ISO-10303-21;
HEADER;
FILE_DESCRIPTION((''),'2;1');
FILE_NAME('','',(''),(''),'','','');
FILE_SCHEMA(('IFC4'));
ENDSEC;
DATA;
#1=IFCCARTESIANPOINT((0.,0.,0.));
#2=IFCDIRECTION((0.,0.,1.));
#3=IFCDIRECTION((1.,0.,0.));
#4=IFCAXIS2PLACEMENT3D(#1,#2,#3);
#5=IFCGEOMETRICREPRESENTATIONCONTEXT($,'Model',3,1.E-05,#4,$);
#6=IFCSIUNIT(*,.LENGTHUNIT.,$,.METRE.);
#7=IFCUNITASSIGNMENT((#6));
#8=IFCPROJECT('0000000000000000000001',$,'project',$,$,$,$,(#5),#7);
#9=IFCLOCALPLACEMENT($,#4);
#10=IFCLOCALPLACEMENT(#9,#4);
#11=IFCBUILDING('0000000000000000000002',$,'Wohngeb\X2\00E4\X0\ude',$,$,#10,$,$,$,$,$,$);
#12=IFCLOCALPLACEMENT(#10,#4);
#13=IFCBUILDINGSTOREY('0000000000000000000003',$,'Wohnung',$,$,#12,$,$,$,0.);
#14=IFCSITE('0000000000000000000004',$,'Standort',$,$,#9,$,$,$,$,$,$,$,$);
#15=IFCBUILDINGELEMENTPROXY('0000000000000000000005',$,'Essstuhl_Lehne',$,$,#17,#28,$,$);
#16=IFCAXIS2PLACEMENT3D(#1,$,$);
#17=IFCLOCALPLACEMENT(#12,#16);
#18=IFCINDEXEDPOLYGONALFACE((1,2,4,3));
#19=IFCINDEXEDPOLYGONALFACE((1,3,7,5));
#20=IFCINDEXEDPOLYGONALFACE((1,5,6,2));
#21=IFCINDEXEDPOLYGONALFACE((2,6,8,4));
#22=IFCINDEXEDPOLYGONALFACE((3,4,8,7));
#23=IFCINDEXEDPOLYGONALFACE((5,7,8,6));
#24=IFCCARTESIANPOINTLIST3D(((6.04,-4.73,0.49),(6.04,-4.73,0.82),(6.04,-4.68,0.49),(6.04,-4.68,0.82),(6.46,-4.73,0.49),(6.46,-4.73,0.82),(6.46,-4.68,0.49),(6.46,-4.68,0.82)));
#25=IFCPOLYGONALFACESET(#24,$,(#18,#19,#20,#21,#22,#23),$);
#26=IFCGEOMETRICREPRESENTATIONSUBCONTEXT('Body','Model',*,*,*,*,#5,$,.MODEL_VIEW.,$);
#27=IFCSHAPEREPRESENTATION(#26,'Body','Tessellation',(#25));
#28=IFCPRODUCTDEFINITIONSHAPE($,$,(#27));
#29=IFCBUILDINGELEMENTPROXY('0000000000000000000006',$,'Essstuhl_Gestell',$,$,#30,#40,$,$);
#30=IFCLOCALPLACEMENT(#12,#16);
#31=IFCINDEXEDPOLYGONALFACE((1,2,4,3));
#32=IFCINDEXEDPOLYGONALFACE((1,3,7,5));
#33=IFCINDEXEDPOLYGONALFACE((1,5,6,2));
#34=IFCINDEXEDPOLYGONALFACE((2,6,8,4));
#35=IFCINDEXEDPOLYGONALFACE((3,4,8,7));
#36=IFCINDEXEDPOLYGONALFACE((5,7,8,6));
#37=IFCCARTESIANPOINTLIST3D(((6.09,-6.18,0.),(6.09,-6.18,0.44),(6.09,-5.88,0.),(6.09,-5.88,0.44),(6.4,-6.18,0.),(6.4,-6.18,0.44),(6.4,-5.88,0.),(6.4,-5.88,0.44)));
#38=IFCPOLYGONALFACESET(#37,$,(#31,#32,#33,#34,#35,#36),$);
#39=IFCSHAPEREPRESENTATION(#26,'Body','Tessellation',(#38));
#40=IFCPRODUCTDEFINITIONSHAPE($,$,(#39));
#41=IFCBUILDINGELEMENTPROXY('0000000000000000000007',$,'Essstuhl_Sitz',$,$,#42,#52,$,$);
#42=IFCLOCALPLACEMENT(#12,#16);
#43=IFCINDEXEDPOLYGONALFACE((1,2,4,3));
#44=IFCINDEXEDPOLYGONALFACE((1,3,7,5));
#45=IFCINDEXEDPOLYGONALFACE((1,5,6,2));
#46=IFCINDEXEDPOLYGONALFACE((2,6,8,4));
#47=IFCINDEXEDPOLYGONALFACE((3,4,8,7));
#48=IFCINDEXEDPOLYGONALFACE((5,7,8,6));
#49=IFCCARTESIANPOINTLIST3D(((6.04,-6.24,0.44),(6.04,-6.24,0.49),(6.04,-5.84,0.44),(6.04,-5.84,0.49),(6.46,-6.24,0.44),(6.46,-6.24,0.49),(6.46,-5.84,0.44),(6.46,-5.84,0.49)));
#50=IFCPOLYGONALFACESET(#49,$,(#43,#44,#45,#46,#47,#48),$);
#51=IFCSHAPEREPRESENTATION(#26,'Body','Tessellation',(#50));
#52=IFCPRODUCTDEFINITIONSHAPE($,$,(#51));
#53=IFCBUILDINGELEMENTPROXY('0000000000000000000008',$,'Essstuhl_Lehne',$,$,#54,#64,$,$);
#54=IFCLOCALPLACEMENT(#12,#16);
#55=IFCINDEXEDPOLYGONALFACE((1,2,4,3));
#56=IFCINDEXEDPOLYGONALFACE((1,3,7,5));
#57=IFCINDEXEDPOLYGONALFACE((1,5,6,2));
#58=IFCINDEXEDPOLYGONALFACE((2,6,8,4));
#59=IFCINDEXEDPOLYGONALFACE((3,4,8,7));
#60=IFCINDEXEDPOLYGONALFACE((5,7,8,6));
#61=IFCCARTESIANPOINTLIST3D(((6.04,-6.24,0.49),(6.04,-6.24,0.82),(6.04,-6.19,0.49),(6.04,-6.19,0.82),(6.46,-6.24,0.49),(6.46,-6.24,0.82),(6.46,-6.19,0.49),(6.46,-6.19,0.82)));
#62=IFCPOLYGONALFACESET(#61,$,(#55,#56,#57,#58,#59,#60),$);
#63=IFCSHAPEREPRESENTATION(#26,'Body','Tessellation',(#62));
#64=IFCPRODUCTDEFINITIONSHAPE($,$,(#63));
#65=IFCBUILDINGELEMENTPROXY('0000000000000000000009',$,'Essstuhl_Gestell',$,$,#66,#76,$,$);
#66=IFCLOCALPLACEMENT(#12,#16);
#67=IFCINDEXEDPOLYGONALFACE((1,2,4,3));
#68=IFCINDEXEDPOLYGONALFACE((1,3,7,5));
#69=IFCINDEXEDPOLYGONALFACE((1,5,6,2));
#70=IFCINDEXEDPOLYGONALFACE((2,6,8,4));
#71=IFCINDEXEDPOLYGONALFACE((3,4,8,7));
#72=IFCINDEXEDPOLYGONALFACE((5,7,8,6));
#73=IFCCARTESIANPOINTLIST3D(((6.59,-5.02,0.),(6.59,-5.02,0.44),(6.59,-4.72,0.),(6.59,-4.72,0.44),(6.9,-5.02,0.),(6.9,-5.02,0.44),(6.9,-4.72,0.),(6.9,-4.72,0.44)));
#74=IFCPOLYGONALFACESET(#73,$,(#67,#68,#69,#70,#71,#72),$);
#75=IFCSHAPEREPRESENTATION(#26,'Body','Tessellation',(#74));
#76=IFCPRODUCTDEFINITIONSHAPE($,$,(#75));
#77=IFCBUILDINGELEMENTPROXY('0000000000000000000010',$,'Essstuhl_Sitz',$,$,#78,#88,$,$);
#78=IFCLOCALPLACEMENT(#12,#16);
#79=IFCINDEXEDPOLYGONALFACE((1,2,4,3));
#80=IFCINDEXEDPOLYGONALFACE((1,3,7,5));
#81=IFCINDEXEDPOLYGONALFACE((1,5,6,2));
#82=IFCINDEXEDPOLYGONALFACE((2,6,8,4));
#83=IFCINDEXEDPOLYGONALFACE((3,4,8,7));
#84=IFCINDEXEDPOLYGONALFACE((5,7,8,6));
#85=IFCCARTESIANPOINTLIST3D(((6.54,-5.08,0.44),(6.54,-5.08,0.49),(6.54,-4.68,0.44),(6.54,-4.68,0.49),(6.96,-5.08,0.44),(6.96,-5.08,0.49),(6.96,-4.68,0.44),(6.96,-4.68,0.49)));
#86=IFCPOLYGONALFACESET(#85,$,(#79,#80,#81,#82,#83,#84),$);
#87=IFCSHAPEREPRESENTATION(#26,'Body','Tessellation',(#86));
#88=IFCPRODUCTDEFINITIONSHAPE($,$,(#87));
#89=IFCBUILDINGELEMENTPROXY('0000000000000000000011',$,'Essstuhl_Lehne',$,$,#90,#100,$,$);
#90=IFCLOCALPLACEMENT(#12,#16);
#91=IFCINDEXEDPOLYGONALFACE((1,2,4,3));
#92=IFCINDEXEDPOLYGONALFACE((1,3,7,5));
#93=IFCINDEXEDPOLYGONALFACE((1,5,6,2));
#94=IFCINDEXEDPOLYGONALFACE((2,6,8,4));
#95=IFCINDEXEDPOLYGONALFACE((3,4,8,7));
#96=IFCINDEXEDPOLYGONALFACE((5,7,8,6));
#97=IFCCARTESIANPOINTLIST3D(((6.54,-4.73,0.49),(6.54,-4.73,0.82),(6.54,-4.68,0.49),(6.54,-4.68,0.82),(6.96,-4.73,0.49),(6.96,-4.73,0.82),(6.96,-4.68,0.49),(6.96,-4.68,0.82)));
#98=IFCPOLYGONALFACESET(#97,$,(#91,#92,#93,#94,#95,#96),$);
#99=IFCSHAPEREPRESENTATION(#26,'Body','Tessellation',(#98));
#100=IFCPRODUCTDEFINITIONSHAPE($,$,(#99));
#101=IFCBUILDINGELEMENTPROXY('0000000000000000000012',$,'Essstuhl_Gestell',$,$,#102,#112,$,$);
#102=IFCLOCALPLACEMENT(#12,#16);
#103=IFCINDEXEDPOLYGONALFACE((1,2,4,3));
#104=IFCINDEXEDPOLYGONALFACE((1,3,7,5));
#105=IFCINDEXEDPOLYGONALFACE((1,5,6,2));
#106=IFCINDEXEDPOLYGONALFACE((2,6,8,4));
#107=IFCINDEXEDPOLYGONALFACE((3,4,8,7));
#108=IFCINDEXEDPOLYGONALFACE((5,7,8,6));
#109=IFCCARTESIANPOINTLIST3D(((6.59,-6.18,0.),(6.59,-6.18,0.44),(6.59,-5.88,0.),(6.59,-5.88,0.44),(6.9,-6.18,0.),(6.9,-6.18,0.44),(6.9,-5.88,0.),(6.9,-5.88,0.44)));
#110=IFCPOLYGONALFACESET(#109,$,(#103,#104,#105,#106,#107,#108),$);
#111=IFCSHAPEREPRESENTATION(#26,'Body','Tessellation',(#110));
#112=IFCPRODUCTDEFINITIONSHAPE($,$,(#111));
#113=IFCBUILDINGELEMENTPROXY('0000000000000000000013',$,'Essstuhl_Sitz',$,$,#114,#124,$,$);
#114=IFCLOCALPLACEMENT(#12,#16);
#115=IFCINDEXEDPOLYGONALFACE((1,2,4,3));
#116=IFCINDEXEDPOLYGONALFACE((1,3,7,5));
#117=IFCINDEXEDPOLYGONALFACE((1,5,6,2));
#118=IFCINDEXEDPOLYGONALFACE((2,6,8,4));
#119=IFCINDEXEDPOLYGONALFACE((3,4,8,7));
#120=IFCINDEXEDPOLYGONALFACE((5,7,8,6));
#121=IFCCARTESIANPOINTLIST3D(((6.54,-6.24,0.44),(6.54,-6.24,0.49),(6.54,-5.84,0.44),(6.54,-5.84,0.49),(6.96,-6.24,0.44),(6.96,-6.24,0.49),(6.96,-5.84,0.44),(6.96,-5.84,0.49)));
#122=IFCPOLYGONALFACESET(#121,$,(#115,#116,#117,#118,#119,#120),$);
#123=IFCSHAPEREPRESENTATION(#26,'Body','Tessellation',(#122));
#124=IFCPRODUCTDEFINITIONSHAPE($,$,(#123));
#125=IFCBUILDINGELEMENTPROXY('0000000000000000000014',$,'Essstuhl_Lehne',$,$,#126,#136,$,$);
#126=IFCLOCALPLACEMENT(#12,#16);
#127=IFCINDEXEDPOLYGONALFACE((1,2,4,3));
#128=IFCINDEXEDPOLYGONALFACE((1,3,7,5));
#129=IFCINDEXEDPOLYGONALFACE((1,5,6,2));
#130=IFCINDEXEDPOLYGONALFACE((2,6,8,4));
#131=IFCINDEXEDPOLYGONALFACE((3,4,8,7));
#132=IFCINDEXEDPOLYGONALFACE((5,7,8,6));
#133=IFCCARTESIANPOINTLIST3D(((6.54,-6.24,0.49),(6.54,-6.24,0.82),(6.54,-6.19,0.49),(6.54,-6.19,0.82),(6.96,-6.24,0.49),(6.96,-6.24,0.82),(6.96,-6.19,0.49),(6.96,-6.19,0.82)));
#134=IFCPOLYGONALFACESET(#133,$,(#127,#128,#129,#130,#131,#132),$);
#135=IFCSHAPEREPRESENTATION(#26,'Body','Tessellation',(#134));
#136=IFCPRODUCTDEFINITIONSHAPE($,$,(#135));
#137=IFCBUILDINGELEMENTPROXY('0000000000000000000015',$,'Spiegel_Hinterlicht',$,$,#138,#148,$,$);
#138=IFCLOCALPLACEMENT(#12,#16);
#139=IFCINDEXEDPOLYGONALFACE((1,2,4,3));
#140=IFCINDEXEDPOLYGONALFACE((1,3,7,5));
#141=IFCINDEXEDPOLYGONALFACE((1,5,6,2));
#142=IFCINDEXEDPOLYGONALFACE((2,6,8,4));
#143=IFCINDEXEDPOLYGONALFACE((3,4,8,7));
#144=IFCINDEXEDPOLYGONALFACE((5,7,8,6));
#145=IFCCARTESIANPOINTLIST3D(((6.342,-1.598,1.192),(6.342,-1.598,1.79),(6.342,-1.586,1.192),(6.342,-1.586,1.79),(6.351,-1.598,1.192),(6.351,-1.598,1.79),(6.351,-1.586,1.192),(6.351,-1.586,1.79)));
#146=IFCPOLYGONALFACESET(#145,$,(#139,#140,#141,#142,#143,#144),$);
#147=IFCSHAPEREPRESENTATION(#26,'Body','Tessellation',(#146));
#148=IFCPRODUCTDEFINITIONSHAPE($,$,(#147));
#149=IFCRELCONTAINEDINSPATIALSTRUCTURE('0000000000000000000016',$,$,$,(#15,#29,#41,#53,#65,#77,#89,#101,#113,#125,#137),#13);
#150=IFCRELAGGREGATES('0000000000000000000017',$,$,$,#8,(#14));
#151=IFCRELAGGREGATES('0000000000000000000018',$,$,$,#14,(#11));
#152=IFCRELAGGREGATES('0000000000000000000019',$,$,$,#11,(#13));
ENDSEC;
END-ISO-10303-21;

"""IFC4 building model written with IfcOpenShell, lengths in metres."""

from ifc_helpers import new_model, si_unit, frame, origin, origin_with_axes, place, context, subcontext, project, spatial, polyline, outline, extrude, element, save


model = new_model("IFC4")

# Units and contexts
model_context = context("Model", 3, precision=1e-05, world=origin_with_axes())
body_context = subcontext(model_context, "Body", "Model", "MODEL_VIEW")
ifc_project = project(units=[si_unit("LENGTHUNIT", "METRE")], contexts=[model_context])

# Site, building, storey
site_placement = place(None, origin_with_axes())
site = spatial("IfcSite", under=ifc_project, at=site_placement, Name="Standort")
building_placement = place(site_placement, origin_with_axes())
building = spatial("IfcBuilding", under=site, at=building_placement, Name="Wohngebäude")
storey_placement = place(building_placement, origin_with_axes())
storey = spatial("IfcBuildingStorey", under=building, at=storey_placement, Name="Wohnung", Elevation=0.0)

# Building element proxies
proxy_1_placement = place(storey_placement, frame((6.04, -4.68, 0.49), z_axis=(0.0, 0.0, 1.0), x_axis=(1.0, 0.0, 0.0)))
element("IfcBuildingElementProxy", 1, at=proxy_1_placement, inside=storey, Name="Essstuhl_Lehne", context=body_context, shape_type="SweptSolid", body=[
    extrude(outline(polyline([(0.0, 0.0), (0.0, -0.05), (0.42, -0.05), (0.42, 0.0), (0.0, 0.0)])), origin(), (0.0, 0.0, 1.0), 0.33),
])
proxy_2_placement = place(storey_placement, frame((6.09, -5.88, 0.0), z_axis=(0.0, 0.0, 1.0), x_axis=(1.0, 0.0, 0.0)))
element("IfcBuildingElementProxy", 2, at=proxy_2_placement, inside=storey, Name="Essstuhl_Gestell", context=body_context, shape_type="SweptSolid", body=[
    extrude(outline(polyline([(0.0, 0.0), (0.0, -0.3), (0.31, -0.3), (0.31, 0.0), (0.0, 0.0)])), origin(), (0.0, 0.0, 1.0), 0.44),
])
proxy_3_placement = place(storey_placement, frame((6.04, -5.84, 0.44), z_axis=(0.0, 0.0, 1.0), x_axis=(1.0, 0.0, 0.0)))
element("IfcBuildingElementProxy", 3, at=proxy_3_placement, inside=storey, Name="Essstuhl_Sitz", context=body_context, shape_type="SweptSolid", body=[
    extrude(outline(polyline([(0.0, 0.0), (0.0, -0.4), (0.42, -0.4), (0.42, 0.0), (0.0, 0.0)])), origin(), (0.0, 0.0, 1.0), 0.05),
])
proxy_4_placement = place(storey_placement, frame((6.04, -6.19, 0.49), z_axis=(0.0, 0.0, 1.0), x_axis=(1.0, 0.0, 0.0)))
element("IfcBuildingElementProxy", 4, at=proxy_4_placement, inside=storey, Name="Essstuhl_Lehne", context=body_context, shape_type="SweptSolid", body=[
    extrude(outline(polyline([(0.0, 0.0), (0.0, -0.05), (0.42, -0.05), (0.42, 0.0), (0.0, 0.0)])), origin(), (0.0, 0.0, 1.0), 0.33),
])
proxy_5_placement = place(storey_placement, frame((6.59, -4.72, 0.0), z_axis=(0.0, 0.0, 1.0), x_axis=(1.0, 0.0, 0.0)))
element("IfcBuildingElementProxy", 5, at=proxy_5_placement, inside=storey, Name="Essstuhl_Gestell", context=body_context, shape_type="SweptSolid", body=[
    extrude(outline(polyline([(0.0, 0.0), (0.0, -0.3), (0.31, -0.3), (0.31, 0.0), (0.0, 0.0)])), origin(), (0.0, 0.0, 1.0), 0.44),
])
proxy_6_placement = place(storey_placement, frame((6.54, -4.68, 0.44), z_axis=(0.0, 0.0, 1.0), x_axis=(1.0, 0.0, 0.0)))
element("IfcBuildingElementProxy", 6, at=proxy_6_placement, inside=storey, Name="Essstuhl_Sitz", context=body_context, shape_type="SweptSolid", body=[
    extrude(outline(polyline([(0.0, 0.0), (0.0, -0.4), (0.42, -0.4), (0.42, 0.0), (0.0, 0.0)])), origin(), (0.0, 0.0, 1.0), 0.05),
])
proxy_7_placement = place(storey_placement, frame((6.54, -4.68, 0.49), z_axis=(0.0, 0.0, 1.0), x_axis=(1.0, 0.0, 0.0)))
element("IfcBuildingElementProxy", 7, at=proxy_7_placement, inside=storey, Name="Essstuhl_Lehne", context=body_context, shape_type="SweptSolid", body=[
    extrude(outline(polyline([(0.0, 0.0), (0.0, -0.05), (0.42, -0.05), (0.42, 0.0), (0.0, 0.0)])), origin(), (0.0, 0.0, 1.0), 0.33),
])
proxy_8_placement = place(storey_placement, frame((6.59, -5.88, 0.0), z_axis=(0.0, 0.0, 1.0), x_axis=(1.0, 0.0, 0.0)))
element("IfcBuildingElementProxy", 8, at=proxy_8_placement, inside=storey, Name="Essstuhl_Gestell", context=body_context, shape_type="SweptSolid", body=[
    extrude(outline(polyline([(0.0, 0.0), (0.0, -0.3), (0.31, -0.3), (0.31, 0.0), (0.0, 0.0)])), origin(), (0.0, 0.0, 1.0), 0.44),
])
proxy_9_placement = place(storey_placement, frame((6.54, -5.84, 0.44), z_axis=(0.0, 0.0, 1.0), x_axis=(1.0, 0.0, 0.0)))
element("IfcBuildingElementProxy", 9, at=proxy_9_placement, inside=storey, Name="Essstuhl_Sitz", context=body_context, shape_type="SweptSolid", body=[
    extrude(outline(polyline([(0.0, 0.0), (0.0, -0.4), (0.42, -0.4), (0.42, 0.0), (0.0, 0.0)])), origin(), (0.0, 0.0, 1.0), 0.05),
])
proxy_10_placement = place(storey_placement, frame((6.54, -6.19, 0.49), z_axis=(0.0, 0.0, 1.0), x_axis=(1.0, 0.0, 0.0)))
element("IfcBuildingElementProxy", 10, at=proxy_10_placement, inside=storey, Name="Essstuhl_Lehne", context=body_context, shape_type="SweptSolid", body=[
    extrude(outline(polyline([(0.0, 0.0), (0.0, -0.05), (0.42, -0.05), (0.42, 0.0), (0.0, 0.0)])), origin(), (0.0, 0.0, 1.0), 0.33),
])
proxy_11_placement = place(storey_placement, frame((6.342, -1.586, 1.192), z_axis=(0.0, 0.0, 1.0), x_axis=(1.0, 0.0, 0.0)))
element("IfcBuildingElementProxy", 11, at=proxy_11_placement, inside=storey, Name="Spiegel_Hinterlicht", context=body_context, shape_type="SweptSolid", body=[
    extrude(outline(polyline([(0.0, 0.0), (0.0, -0.012), (0.009, -0.012), (0.009, 0.0), (0.0, 0.0)])), origin(), (0.0, 0.0, 1.0), 0.598),
])

save(model, "model.ifc")
